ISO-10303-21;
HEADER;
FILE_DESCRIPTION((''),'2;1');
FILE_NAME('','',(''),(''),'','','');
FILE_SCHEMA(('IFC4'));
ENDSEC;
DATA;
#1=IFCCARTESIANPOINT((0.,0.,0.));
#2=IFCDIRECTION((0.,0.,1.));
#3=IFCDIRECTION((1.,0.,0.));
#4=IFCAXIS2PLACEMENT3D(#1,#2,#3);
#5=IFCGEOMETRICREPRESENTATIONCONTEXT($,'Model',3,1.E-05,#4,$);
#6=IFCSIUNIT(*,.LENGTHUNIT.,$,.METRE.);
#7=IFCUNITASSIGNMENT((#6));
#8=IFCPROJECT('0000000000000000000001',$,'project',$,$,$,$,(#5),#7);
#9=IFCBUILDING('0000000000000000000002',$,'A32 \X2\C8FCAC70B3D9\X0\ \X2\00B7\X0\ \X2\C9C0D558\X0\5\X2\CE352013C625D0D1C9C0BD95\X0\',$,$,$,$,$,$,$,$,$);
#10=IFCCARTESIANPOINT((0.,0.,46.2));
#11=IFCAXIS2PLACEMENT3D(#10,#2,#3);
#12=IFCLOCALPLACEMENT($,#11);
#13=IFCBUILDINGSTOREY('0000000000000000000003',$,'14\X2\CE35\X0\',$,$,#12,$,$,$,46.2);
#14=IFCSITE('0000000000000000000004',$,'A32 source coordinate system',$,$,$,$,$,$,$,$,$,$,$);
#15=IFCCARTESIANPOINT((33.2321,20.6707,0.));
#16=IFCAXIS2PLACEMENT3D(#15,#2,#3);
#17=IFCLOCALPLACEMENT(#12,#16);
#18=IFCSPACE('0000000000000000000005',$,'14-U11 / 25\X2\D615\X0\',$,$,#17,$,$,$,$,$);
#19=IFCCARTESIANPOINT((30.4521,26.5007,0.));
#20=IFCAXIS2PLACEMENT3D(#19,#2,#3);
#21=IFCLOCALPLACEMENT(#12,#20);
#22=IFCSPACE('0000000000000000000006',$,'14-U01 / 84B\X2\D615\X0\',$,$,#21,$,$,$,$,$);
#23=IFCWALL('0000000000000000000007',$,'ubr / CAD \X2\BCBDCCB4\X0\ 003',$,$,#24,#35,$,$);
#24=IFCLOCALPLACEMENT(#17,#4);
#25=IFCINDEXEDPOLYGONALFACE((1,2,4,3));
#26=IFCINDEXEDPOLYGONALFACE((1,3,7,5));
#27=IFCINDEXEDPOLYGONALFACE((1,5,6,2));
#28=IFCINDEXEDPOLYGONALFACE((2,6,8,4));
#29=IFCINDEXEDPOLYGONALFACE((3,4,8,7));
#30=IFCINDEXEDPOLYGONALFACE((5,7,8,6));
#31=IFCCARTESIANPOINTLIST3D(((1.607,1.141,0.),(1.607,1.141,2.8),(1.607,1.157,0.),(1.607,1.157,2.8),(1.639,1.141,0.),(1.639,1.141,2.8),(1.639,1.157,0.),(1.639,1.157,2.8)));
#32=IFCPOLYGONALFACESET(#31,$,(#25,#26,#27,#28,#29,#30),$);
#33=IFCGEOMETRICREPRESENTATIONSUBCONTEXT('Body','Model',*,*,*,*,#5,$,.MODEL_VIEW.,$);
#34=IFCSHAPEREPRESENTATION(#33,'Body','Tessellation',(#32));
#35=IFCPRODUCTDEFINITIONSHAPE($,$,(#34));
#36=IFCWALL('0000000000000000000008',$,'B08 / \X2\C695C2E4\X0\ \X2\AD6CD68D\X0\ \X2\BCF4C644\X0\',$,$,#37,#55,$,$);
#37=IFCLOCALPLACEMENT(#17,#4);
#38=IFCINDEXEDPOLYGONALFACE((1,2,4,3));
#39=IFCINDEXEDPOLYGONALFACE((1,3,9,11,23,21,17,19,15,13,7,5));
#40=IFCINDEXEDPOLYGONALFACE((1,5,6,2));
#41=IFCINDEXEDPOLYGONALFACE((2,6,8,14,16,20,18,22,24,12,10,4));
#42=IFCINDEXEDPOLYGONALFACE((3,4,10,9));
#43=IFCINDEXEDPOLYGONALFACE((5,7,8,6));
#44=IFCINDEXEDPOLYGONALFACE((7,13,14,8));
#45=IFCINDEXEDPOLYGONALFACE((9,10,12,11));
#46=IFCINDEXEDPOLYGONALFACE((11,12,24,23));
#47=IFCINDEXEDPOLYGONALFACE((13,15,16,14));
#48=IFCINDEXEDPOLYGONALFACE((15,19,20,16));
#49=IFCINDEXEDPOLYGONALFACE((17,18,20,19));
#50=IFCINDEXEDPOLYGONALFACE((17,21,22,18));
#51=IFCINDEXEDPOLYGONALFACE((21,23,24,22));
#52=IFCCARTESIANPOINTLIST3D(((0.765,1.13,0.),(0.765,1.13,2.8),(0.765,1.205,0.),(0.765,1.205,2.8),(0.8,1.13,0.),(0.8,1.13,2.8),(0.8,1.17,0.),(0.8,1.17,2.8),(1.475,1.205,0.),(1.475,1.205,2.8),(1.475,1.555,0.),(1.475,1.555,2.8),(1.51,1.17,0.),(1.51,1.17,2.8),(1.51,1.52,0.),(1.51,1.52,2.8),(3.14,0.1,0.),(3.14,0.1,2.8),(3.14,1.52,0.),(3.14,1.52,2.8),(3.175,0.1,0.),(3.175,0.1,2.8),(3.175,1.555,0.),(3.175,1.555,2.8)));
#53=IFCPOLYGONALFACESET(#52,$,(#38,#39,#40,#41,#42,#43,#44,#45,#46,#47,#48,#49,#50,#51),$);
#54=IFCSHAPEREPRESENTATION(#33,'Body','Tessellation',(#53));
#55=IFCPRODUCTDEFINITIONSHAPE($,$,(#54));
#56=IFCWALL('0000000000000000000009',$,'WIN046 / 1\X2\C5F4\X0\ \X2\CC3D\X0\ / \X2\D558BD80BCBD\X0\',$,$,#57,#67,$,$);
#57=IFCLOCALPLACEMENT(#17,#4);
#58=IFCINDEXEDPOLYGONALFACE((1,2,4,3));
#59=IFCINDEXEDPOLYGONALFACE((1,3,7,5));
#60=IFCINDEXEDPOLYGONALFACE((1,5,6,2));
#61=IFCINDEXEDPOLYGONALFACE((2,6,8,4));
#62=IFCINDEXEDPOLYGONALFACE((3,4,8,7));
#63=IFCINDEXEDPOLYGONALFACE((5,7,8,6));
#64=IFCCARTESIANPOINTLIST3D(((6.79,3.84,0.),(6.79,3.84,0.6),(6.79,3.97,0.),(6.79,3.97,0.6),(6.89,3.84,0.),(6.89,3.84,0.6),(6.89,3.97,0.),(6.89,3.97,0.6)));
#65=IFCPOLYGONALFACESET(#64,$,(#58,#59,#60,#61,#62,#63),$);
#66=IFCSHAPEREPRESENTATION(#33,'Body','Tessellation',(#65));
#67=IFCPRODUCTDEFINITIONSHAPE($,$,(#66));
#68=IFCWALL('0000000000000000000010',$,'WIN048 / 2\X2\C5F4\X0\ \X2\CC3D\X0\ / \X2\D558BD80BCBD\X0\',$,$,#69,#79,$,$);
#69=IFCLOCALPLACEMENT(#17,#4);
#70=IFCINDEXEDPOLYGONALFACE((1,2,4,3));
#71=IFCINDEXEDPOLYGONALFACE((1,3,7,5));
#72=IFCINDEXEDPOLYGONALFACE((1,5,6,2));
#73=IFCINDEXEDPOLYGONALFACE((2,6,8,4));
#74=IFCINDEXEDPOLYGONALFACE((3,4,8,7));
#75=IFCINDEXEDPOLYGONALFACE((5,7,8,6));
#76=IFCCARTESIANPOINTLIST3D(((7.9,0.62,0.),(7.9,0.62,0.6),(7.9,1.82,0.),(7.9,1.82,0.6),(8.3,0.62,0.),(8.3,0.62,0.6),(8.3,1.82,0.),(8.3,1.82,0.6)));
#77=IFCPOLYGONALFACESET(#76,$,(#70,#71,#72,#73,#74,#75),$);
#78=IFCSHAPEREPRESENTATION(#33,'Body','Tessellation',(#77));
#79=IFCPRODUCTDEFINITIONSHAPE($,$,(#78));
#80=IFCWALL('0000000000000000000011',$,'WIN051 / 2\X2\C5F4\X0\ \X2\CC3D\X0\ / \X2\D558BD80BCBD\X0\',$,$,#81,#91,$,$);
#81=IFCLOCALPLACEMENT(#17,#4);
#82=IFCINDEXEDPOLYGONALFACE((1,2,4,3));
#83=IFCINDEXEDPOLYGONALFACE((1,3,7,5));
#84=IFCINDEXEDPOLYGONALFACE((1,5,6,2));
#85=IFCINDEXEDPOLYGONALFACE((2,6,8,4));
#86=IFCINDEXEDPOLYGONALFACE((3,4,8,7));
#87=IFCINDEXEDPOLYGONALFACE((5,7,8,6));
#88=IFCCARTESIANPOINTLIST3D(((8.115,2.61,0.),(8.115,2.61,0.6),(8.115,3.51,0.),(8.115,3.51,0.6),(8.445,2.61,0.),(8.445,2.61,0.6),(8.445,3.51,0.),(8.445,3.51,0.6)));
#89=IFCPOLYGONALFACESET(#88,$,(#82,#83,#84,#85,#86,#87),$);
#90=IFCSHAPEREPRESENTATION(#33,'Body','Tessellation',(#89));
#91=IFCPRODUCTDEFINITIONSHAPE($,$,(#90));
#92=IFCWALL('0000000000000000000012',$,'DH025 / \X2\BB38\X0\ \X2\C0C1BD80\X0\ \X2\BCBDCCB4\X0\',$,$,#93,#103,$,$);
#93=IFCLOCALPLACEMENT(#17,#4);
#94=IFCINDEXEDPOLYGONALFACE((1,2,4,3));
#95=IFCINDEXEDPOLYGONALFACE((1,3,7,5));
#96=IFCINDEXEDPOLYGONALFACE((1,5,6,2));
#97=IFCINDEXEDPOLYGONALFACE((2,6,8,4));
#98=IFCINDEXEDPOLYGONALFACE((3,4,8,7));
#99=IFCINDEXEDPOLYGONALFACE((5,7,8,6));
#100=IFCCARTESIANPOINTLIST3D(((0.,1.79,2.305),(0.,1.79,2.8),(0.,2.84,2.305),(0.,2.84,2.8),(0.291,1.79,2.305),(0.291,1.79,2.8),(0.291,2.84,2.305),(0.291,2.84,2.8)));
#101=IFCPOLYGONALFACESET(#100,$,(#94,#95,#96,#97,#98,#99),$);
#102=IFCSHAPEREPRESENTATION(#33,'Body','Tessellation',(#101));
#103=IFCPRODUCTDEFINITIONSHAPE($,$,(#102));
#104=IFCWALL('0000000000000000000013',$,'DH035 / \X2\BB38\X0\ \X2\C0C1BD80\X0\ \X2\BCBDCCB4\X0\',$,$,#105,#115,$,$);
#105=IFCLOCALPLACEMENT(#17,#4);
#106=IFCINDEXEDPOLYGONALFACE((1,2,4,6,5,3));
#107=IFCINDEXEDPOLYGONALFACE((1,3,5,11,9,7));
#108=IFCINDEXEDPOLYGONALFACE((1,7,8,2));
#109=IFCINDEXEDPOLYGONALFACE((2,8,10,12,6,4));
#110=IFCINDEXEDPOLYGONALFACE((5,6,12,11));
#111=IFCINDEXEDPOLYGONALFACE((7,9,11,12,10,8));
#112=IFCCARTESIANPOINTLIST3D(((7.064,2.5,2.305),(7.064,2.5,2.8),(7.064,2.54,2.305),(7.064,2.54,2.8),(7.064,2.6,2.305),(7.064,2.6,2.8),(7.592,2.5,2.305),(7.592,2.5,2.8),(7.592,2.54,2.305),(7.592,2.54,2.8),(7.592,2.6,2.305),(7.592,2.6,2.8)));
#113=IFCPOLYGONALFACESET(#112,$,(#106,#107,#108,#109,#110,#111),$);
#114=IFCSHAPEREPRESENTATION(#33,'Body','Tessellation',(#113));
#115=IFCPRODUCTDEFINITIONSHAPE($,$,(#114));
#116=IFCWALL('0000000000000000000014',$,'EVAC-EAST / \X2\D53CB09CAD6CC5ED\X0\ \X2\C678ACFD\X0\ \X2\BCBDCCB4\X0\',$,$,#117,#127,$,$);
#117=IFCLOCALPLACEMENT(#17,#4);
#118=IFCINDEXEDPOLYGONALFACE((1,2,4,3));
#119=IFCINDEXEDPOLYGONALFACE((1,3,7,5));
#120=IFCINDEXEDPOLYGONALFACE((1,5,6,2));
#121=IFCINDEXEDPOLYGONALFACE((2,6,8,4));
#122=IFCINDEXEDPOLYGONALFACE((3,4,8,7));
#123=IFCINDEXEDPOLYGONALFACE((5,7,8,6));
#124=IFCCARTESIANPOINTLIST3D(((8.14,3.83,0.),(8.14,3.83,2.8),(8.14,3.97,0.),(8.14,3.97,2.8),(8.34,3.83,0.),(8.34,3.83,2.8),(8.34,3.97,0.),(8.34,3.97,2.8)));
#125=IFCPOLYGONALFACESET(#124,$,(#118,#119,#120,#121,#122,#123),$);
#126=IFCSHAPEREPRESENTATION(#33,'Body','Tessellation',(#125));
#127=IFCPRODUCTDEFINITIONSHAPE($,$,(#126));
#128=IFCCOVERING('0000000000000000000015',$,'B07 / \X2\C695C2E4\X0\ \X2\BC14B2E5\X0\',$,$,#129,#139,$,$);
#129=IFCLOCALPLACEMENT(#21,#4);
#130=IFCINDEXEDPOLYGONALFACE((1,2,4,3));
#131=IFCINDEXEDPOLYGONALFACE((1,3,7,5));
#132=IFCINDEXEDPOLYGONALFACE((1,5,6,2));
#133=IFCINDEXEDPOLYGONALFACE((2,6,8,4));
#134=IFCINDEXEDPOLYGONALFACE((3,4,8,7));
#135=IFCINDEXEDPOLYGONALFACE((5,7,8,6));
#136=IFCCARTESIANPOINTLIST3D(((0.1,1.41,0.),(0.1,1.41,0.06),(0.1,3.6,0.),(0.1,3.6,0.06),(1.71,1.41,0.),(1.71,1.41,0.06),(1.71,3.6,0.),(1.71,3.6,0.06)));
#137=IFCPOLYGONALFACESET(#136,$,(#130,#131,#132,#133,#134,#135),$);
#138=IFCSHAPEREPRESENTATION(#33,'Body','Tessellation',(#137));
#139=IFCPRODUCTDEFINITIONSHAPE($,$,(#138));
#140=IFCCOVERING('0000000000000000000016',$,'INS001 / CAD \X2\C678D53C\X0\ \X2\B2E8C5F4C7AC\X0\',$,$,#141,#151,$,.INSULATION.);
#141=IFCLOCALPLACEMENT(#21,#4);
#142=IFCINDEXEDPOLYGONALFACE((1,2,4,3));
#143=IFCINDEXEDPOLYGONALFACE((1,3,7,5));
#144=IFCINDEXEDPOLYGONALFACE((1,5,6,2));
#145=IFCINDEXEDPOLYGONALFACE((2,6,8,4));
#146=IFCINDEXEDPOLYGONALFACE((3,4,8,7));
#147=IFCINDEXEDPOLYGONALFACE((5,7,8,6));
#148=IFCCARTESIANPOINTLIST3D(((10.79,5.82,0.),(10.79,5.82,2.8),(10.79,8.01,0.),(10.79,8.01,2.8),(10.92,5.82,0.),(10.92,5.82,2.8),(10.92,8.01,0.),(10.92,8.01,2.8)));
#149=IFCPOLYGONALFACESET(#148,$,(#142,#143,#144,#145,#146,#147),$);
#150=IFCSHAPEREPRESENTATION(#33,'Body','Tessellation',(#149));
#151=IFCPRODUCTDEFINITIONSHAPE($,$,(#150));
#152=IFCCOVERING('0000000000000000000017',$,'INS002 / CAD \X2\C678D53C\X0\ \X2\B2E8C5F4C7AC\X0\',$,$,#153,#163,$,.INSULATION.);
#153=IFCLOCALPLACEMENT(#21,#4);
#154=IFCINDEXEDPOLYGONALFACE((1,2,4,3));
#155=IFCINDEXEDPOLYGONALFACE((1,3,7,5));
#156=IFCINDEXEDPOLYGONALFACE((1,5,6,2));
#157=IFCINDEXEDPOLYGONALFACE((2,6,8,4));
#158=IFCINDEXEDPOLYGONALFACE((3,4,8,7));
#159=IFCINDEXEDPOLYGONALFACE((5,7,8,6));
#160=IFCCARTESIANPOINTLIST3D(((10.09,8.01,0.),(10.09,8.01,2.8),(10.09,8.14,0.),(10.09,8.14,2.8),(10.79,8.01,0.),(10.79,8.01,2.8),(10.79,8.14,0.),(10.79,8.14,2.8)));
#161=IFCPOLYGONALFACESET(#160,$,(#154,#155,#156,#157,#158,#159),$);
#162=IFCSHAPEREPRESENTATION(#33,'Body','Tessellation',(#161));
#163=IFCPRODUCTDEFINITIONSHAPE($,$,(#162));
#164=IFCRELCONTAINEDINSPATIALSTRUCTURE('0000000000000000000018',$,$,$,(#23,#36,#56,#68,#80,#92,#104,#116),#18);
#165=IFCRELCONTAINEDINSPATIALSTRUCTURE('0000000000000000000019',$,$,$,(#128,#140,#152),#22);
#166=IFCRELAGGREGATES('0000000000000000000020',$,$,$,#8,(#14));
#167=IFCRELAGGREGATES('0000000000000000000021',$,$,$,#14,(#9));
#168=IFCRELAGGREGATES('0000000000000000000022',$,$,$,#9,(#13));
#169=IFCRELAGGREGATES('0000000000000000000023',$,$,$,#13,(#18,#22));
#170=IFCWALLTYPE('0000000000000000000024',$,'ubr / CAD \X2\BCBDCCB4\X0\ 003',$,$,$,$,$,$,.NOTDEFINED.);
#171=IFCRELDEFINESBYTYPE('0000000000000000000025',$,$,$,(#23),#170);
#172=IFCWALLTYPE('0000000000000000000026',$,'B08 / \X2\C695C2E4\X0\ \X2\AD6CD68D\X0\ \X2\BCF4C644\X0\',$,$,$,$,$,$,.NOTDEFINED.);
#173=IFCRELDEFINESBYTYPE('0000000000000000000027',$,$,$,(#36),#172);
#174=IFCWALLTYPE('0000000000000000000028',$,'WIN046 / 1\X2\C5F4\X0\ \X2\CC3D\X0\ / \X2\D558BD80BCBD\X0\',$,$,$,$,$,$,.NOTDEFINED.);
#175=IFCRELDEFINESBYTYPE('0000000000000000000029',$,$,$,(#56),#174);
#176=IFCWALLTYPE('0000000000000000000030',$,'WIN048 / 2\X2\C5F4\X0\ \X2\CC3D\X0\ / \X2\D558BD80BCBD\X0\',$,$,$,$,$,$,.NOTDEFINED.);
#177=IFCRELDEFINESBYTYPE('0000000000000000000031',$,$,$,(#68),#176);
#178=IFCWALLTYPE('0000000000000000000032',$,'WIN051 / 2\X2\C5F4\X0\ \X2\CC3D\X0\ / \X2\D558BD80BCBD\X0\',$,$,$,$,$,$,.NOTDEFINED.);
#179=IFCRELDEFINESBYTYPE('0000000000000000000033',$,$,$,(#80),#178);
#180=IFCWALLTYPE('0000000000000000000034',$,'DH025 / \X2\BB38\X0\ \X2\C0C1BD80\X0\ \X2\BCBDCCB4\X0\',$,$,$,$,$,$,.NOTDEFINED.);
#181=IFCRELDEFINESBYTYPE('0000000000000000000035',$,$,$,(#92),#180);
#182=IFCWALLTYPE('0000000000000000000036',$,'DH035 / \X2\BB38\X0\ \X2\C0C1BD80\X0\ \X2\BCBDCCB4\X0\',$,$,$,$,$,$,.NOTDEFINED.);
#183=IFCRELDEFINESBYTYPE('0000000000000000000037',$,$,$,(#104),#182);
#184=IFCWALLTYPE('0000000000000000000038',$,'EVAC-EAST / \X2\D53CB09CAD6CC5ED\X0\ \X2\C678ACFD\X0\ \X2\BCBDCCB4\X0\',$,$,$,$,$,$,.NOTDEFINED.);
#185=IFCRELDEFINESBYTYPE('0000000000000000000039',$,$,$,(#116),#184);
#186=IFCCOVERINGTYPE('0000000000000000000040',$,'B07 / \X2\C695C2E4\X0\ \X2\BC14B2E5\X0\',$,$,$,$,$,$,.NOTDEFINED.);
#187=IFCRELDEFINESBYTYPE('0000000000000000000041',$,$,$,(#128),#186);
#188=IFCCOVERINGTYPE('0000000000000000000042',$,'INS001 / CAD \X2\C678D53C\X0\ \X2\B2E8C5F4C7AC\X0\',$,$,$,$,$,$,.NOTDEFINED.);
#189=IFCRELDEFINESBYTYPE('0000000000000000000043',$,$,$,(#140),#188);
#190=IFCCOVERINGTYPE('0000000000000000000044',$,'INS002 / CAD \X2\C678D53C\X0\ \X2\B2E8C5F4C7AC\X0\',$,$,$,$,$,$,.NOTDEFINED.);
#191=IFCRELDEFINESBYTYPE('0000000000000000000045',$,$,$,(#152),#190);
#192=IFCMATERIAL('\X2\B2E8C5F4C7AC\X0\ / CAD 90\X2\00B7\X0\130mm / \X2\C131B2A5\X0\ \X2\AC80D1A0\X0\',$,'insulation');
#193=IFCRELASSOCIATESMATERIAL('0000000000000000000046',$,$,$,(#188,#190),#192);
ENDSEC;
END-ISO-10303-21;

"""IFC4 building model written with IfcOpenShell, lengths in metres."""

from ifc_helpers import new_model, si_unit, frame, origin, origin_with_axes, place, context, subcontext, project, spatial, polyline, outline, extrude, source, transform, mapped, material, type_object, type_shapes, element, save


model = new_model("IFC4")

# Units and contexts
model_context = context("Model", 3, precision=1e-05, world=origin_with_axes())
body_context = subcontext(model_context, "Body", "Model", "MODEL_VIEW")
ifc_project = project(units=[si_unit("LENGTHUNIT", "METRE")], contexts=[model_context])

# Site, building, storey, space
site = spatial("IfcSite", under=ifc_project, Name="A32 source coordinate system")
building = spatial("IfcBuilding", under=site, Name="A32 주거동 · 지하5층–옥탑지붕")
storey_placement = place(None, frame((0.0, 0.0, 46.2), z_axis=(0.0, 0.0, 1.0), x_axis=(1.0, 0.0, 0.0)))
storey = spatial("IfcBuildingStorey", under=building, at=storey_placement, Name="14층", Elevation=46.2)
space_1_placement = place(storey_placement, frame((33.2321, 20.6707, 0.0), z_axis=(0.0, 0.0, 1.0), x_axis=(1.0, 0.0, 0.0)))
space_1 = spatial("IfcSpace", under=storey, at=space_1_placement, Name="14-U11 / 25형")

# Walls
wall_type_1 = type_object("IfcWallType", Name="ubr / CAD 벽체 003", PredefinedType="NOTDEFINED")
shared_shape_1 = source(origin(), body_context, "Body", "SweptSolid", [
    extrude(outline(polyline([(1.639, 1.157), (1.639, 1.141), (1.607, 1.141), (1.607, 1.157), (1.639, 1.157)])), origin(), (0.0, 0.0, 1.0), 2.8),
])
type_shapes(wall_type_1, [shared_shape_1])
wall_1_placement = place(space_1_placement, origin_with_axes())
element("IfcWall", 1, at=wall_1_placement, inside=space_1, type_object=wall_type_1, Name="ubr / CAD 벽체 003", context=body_context, shape_type="MappedRepresentation", body=[
    mapped(shared_shape_1, transform((0.0, 0.0, 0.0), scale=1.0)),
])
wall_type_2 = type_object("IfcWallType", Name="B08 / 욕실 구획 보완", PredefinedType="NOTDEFINED")
shared_shape_2 = source(origin(), body_context, "Body", "SweptSolid", [
    extrude(outline(polyline([(0.765, 1.205), (1.475, 1.205), (1.475, 1.555), (3.175, 1.555), (3.175, 0.1), (3.14, 0.1), (3.14, 1.52), (1.51, 1.52), (1.51, 1.17), (0.8, 1.17), (0.8, 1.13), (0.765, 1.13), (0.765, 1.205)])), origin(), (0.0, 0.0, 1.0), 2.8),
])
type_shapes(wall_type_2, [shared_shape_2])
wall_2_placement = place(space_1_placement, origin_with_axes())
element("IfcWall", 2, at=wall_2_placement, inside=space_1, type_object=wall_type_2, Name="B08 / 욕실 구획 보완", context=body_context, shape_type="MappedRepresentation", body=[
    mapped(shared_shape_2, transform((0.0, 0.0, 0.0), scale=1.0)),
])
wall_type_3 = type_object("IfcWallType", Name="WIN046 / 1열 창 / 하부벽", PredefinedType="NOTDEFINED")
shared_shape_3 = source(origin(), body_context, "Body", "SweptSolid", [
    extrude(outline(polyline([(6.89, 3.84), (6.79, 3.84), (6.79, 3.97), (6.89, 3.97), (6.89, 3.84)])), origin(), (0.0, 0.0, 1.0), 0.6),
])
type_shapes(wall_type_3, [shared_shape_3])
wall_3_placement = place(space_1_placement, origin_with_axes())
element("IfcWall", 3, at=wall_3_placement, inside=space_1, type_object=wall_type_3, Name="WIN046 / 1열 창 / 하부벽", context=body_context, shape_type="MappedRepresentation", body=[
    mapped(shared_shape_3, transform((0.0, 0.0, 0.0), scale=1.0)),
])
wall_type_4 = type_object("IfcWallType", Name="WIN048 / 2열 창 / 하부벽", PredefinedType="NOTDEFINED")
shared_shape_4 = source(origin(), body_context, "Body", "SweptSolid", [
    extrude(outline(polyline([(8.3, 0.62), (7.9, 0.62), (7.9, 1.82), (8.3, 1.82), (8.3, 0.62)])), origin(), (0.0, 0.0, 1.0), 0.6),
])
type_shapes(wall_type_4, [shared_shape_4])
wall_4_placement = place(space_1_placement, origin_with_axes())
element("IfcWall", 4, at=wall_4_placement, inside=space_1, type_object=wall_type_4, Name="WIN048 / 2열 창 / 하부벽", context=body_context, shape_type="MappedRepresentation", body=[
    mapped(shared_shape_4, transform((0.0, 0.0, 0.0), scale=1.0)),
])
wall_type_5 = type_object("IfcWallType", Name="WIN051 / 2열 창 / 하부벽", PredefinedType="NOTDEFINED")
shared_shape_5 = source(origin(), body_context, "Body", "SweptSolid", [
    extrude(outline(polyline([(8.445, 2.61), (8.115, 2.61), (8.115, 3.51), (8.445, 3.51), (8.445, 2.61)])), origin(), (0.0, 0.0, 1.0), 0.6),
])
type_shapes(wall_type_5, [shared_shape_5])
wall_5_placement = place(space_1_placement, origin_with_axes())
element("IfcWall", 5, at=wall_5_placement, inside=space_1, type_object=wall_type_5, Name="WIN051 / 2열 창 / 하부벽", context=body_context, shape_type="MappedRepresentation", body=[
    mapped(shared_shape_5, transform((0.0, 0.0, 0.0), scale=1.0)),
])
wall_type_6 = type_object("IfcWallType", Name="DH025 / 문 상부 벽체", PredefinedType="NOTDEFINED")
shared_shape_6 = source(origin(), body_context, "Body", "SweptSolid", [
    extrude(outline(polyline([(0.0, 1.79), (0.0, 2.84), (0.291, 2.84), (0.291, 1.79), (0.0, 1.79)])), frame((0.0, 0.0, 2.305)), (0.0, 0.0, 1.0), 0.495),
])
type_shapes(wall_type_6, [shared_shape_6])
wall_6_placement = place(space_1_placement, origin_with_axes())
element("IfcWall", 6, at=wall_6_placement, inside=space_1, type_object=wall_type_6, Name="DH025 / 문 상부 벽체", context=body_context, shape_type="MappedRepresentation", body=[
    mapped(shared_shape_6, transform((0.0, 0.0, 0.0), scale=1.0)),
])
wall_type_7 = type_object("IfcWallType", Name="DH035 / 문 상부 벽체", PredefinedType="NOTDEFINED")
shared_shape_7 = source(origin(), body_context, "Body", "SweptSolid", [
    extrude(outline(polyline([(7.592, 2.6), (7.592, 2.54), (7.592, 2.5), (7.064, 2.5), (7.064, 2.54), (7.064, 2.6), (7.592, 2.6)])), frame((0.0, 0.0, 2.305)), (0.0, 0.0, 1.0), 0.495),
])
type_shapes(wall_type_7, [shared_shape_7])
wall_7_placement = place(space_1_placement, origin_with_axes())
element("IfcWall", 7, at=wall_7_placement, inside=space_1, type_object=wall_type_7, Name="DH035 / 문 상부 벽체", context=body_context, shape_type="MappedRepresentation", body=[
    mapped(shared_shape_7, transform((0.0, 0.0, 0.0), scale=1.0)),
])
wall_type_8 = type_object("IfcWallType", Name="EVAC-EAST / 피난구역 외곽 벽체", PredefinedType="NOTDEFINED")
shared_shape_8 = source(origin(), body_context, "Body", "SweptSolid", [
    extrude(outline(polyline([(8.34, 3.83), (8.14, 3.83), (8.14, 3.97), (8.34, 3.97), (8.34, 3.83)])), origin(), (0.0, 0.0, 1.0), 2.8),
])
type_shapes(wall_type_8, [shared_shape_8])
wall_8_placement = place(space_1_placement, origin_with_axes())
element("IfcWall", 8, at=wall_8_placement, inside=space_1, type_object=wall_type_8, Name="EVAC-EAST / 피난구역 외곽 벽체", context=body_context, shape_type="MappedRepresentation", body=[
    mapped(shared_shape_8, transform((0.0, 0.0, 0.0), scale=1.0)),
])

# Shared definitions
space_2_placement = place(storey_placement, frame((30.4521, 26.5007, 0.0), z_axis=(0.0, 0.0, 1.0), x_axis=(1.0, 0.0, 0.0)))
space_2 = spatial("IfcSpace", under=storey, at=space_2_placement, Name="14-U01 / 84B형")

# Coverings
covering_type_1 = type_object("IfcCoveringType", Name="B07 / 욕실 바닥", PredefinedType="NOTDEFINED")
shared_shape_9 = source(origin(), body_context, "Body", "SweptSolid", [
    extrude(outline(polyline([(1.71, 1.41), (0.1, 1.41), (0.1, 3.6), (1.71, 3.6), (1.71, 1.41)])), origin(), (0.0, 0.0, 1.0), 0.06),
])
type_shapes(covering_type_1, [shared_shape_9])
covering_1_placement = place(space_2_placement, origin_with_axes())
element("IfcCovering", 9, at=covering_1_placement, inside=space_2, type_object=covering_type_1, Name="B07 / 욕실 바닥", context=body_context, shape_type="MappedRepresentation", body=[
    mapped(shared_shape_9, transform((0.0, 0.0, 0.0), scale=1.0)),
])
ifc_material = material(Name="단열재 / CAD 90·130mm / 성능 검토", Category="insulation")
covering_type_2 = type_object("IfcCoveringType", Name="INS001 / CAD 외피 단열재", PredefinedType="NOTDEFINED", material=ifc_material)
shared_shape_10 = source(origin(), body_context, "Body", "SweptSolid", [
    extrude(outline(polyline([(10.79, 5.82), (10.79, 8.01), (10.92, 8.01), (10.92, 5.82), (10.79, 5.82)])), origin(), (0.0, 0.0, 1.0), 2.8),
])
type_shapes(covering_type_2, [shared_shape_10])
covering_2_placement = place(space_2_placement, origin_with_axes())
element("IfcCovering", 10, at=covering_2_placement, inside=space_2, type_object=covering_type_2, Name="INS001 / CAD 외피 단열재", PredefinedType="INSULATION", context=body_context, shape_type="MappedRepresentation", body=[
    mapped(shared_shape_10, transform((0.0, 0.0, 0.0), scale=1.0)),
])
covering_type_3 = type_object("IfcCoveringType", Name="INS002 / CAD 외피 단열재", PredefinedType="NOTDEFINED", material=ifc_material)
shared_shape_11 = source(origin(), body_context, "Body", "SweptSolid", [
    extrude(outline(polyline([(10.79, 8.01), (10.09, 8.01), (10.09, 8.14), (10.79, 8.14), (10.79, 8.01)])), origin(), (0.0, 0.0, 1.0), 2.8),
])
type_shapes(covering_type_3, [shared_shape_11])
covering_3_placement = place(space_2_placement, origin_with_axes())
element("IfcCovering", 11, at=covering_3_placement, inside=space_2, type_object=covering_type_3, Name="INS002 / CAD 외피 단열재", PredefinedType="INSULATION", context=body_context, shape_type="MappedRepresentation", body=[
    mapped(shared_shape_11, transform((0.0, 0.0, 0.0), scale=1.0)),
])

save(model, "model.ifc")
